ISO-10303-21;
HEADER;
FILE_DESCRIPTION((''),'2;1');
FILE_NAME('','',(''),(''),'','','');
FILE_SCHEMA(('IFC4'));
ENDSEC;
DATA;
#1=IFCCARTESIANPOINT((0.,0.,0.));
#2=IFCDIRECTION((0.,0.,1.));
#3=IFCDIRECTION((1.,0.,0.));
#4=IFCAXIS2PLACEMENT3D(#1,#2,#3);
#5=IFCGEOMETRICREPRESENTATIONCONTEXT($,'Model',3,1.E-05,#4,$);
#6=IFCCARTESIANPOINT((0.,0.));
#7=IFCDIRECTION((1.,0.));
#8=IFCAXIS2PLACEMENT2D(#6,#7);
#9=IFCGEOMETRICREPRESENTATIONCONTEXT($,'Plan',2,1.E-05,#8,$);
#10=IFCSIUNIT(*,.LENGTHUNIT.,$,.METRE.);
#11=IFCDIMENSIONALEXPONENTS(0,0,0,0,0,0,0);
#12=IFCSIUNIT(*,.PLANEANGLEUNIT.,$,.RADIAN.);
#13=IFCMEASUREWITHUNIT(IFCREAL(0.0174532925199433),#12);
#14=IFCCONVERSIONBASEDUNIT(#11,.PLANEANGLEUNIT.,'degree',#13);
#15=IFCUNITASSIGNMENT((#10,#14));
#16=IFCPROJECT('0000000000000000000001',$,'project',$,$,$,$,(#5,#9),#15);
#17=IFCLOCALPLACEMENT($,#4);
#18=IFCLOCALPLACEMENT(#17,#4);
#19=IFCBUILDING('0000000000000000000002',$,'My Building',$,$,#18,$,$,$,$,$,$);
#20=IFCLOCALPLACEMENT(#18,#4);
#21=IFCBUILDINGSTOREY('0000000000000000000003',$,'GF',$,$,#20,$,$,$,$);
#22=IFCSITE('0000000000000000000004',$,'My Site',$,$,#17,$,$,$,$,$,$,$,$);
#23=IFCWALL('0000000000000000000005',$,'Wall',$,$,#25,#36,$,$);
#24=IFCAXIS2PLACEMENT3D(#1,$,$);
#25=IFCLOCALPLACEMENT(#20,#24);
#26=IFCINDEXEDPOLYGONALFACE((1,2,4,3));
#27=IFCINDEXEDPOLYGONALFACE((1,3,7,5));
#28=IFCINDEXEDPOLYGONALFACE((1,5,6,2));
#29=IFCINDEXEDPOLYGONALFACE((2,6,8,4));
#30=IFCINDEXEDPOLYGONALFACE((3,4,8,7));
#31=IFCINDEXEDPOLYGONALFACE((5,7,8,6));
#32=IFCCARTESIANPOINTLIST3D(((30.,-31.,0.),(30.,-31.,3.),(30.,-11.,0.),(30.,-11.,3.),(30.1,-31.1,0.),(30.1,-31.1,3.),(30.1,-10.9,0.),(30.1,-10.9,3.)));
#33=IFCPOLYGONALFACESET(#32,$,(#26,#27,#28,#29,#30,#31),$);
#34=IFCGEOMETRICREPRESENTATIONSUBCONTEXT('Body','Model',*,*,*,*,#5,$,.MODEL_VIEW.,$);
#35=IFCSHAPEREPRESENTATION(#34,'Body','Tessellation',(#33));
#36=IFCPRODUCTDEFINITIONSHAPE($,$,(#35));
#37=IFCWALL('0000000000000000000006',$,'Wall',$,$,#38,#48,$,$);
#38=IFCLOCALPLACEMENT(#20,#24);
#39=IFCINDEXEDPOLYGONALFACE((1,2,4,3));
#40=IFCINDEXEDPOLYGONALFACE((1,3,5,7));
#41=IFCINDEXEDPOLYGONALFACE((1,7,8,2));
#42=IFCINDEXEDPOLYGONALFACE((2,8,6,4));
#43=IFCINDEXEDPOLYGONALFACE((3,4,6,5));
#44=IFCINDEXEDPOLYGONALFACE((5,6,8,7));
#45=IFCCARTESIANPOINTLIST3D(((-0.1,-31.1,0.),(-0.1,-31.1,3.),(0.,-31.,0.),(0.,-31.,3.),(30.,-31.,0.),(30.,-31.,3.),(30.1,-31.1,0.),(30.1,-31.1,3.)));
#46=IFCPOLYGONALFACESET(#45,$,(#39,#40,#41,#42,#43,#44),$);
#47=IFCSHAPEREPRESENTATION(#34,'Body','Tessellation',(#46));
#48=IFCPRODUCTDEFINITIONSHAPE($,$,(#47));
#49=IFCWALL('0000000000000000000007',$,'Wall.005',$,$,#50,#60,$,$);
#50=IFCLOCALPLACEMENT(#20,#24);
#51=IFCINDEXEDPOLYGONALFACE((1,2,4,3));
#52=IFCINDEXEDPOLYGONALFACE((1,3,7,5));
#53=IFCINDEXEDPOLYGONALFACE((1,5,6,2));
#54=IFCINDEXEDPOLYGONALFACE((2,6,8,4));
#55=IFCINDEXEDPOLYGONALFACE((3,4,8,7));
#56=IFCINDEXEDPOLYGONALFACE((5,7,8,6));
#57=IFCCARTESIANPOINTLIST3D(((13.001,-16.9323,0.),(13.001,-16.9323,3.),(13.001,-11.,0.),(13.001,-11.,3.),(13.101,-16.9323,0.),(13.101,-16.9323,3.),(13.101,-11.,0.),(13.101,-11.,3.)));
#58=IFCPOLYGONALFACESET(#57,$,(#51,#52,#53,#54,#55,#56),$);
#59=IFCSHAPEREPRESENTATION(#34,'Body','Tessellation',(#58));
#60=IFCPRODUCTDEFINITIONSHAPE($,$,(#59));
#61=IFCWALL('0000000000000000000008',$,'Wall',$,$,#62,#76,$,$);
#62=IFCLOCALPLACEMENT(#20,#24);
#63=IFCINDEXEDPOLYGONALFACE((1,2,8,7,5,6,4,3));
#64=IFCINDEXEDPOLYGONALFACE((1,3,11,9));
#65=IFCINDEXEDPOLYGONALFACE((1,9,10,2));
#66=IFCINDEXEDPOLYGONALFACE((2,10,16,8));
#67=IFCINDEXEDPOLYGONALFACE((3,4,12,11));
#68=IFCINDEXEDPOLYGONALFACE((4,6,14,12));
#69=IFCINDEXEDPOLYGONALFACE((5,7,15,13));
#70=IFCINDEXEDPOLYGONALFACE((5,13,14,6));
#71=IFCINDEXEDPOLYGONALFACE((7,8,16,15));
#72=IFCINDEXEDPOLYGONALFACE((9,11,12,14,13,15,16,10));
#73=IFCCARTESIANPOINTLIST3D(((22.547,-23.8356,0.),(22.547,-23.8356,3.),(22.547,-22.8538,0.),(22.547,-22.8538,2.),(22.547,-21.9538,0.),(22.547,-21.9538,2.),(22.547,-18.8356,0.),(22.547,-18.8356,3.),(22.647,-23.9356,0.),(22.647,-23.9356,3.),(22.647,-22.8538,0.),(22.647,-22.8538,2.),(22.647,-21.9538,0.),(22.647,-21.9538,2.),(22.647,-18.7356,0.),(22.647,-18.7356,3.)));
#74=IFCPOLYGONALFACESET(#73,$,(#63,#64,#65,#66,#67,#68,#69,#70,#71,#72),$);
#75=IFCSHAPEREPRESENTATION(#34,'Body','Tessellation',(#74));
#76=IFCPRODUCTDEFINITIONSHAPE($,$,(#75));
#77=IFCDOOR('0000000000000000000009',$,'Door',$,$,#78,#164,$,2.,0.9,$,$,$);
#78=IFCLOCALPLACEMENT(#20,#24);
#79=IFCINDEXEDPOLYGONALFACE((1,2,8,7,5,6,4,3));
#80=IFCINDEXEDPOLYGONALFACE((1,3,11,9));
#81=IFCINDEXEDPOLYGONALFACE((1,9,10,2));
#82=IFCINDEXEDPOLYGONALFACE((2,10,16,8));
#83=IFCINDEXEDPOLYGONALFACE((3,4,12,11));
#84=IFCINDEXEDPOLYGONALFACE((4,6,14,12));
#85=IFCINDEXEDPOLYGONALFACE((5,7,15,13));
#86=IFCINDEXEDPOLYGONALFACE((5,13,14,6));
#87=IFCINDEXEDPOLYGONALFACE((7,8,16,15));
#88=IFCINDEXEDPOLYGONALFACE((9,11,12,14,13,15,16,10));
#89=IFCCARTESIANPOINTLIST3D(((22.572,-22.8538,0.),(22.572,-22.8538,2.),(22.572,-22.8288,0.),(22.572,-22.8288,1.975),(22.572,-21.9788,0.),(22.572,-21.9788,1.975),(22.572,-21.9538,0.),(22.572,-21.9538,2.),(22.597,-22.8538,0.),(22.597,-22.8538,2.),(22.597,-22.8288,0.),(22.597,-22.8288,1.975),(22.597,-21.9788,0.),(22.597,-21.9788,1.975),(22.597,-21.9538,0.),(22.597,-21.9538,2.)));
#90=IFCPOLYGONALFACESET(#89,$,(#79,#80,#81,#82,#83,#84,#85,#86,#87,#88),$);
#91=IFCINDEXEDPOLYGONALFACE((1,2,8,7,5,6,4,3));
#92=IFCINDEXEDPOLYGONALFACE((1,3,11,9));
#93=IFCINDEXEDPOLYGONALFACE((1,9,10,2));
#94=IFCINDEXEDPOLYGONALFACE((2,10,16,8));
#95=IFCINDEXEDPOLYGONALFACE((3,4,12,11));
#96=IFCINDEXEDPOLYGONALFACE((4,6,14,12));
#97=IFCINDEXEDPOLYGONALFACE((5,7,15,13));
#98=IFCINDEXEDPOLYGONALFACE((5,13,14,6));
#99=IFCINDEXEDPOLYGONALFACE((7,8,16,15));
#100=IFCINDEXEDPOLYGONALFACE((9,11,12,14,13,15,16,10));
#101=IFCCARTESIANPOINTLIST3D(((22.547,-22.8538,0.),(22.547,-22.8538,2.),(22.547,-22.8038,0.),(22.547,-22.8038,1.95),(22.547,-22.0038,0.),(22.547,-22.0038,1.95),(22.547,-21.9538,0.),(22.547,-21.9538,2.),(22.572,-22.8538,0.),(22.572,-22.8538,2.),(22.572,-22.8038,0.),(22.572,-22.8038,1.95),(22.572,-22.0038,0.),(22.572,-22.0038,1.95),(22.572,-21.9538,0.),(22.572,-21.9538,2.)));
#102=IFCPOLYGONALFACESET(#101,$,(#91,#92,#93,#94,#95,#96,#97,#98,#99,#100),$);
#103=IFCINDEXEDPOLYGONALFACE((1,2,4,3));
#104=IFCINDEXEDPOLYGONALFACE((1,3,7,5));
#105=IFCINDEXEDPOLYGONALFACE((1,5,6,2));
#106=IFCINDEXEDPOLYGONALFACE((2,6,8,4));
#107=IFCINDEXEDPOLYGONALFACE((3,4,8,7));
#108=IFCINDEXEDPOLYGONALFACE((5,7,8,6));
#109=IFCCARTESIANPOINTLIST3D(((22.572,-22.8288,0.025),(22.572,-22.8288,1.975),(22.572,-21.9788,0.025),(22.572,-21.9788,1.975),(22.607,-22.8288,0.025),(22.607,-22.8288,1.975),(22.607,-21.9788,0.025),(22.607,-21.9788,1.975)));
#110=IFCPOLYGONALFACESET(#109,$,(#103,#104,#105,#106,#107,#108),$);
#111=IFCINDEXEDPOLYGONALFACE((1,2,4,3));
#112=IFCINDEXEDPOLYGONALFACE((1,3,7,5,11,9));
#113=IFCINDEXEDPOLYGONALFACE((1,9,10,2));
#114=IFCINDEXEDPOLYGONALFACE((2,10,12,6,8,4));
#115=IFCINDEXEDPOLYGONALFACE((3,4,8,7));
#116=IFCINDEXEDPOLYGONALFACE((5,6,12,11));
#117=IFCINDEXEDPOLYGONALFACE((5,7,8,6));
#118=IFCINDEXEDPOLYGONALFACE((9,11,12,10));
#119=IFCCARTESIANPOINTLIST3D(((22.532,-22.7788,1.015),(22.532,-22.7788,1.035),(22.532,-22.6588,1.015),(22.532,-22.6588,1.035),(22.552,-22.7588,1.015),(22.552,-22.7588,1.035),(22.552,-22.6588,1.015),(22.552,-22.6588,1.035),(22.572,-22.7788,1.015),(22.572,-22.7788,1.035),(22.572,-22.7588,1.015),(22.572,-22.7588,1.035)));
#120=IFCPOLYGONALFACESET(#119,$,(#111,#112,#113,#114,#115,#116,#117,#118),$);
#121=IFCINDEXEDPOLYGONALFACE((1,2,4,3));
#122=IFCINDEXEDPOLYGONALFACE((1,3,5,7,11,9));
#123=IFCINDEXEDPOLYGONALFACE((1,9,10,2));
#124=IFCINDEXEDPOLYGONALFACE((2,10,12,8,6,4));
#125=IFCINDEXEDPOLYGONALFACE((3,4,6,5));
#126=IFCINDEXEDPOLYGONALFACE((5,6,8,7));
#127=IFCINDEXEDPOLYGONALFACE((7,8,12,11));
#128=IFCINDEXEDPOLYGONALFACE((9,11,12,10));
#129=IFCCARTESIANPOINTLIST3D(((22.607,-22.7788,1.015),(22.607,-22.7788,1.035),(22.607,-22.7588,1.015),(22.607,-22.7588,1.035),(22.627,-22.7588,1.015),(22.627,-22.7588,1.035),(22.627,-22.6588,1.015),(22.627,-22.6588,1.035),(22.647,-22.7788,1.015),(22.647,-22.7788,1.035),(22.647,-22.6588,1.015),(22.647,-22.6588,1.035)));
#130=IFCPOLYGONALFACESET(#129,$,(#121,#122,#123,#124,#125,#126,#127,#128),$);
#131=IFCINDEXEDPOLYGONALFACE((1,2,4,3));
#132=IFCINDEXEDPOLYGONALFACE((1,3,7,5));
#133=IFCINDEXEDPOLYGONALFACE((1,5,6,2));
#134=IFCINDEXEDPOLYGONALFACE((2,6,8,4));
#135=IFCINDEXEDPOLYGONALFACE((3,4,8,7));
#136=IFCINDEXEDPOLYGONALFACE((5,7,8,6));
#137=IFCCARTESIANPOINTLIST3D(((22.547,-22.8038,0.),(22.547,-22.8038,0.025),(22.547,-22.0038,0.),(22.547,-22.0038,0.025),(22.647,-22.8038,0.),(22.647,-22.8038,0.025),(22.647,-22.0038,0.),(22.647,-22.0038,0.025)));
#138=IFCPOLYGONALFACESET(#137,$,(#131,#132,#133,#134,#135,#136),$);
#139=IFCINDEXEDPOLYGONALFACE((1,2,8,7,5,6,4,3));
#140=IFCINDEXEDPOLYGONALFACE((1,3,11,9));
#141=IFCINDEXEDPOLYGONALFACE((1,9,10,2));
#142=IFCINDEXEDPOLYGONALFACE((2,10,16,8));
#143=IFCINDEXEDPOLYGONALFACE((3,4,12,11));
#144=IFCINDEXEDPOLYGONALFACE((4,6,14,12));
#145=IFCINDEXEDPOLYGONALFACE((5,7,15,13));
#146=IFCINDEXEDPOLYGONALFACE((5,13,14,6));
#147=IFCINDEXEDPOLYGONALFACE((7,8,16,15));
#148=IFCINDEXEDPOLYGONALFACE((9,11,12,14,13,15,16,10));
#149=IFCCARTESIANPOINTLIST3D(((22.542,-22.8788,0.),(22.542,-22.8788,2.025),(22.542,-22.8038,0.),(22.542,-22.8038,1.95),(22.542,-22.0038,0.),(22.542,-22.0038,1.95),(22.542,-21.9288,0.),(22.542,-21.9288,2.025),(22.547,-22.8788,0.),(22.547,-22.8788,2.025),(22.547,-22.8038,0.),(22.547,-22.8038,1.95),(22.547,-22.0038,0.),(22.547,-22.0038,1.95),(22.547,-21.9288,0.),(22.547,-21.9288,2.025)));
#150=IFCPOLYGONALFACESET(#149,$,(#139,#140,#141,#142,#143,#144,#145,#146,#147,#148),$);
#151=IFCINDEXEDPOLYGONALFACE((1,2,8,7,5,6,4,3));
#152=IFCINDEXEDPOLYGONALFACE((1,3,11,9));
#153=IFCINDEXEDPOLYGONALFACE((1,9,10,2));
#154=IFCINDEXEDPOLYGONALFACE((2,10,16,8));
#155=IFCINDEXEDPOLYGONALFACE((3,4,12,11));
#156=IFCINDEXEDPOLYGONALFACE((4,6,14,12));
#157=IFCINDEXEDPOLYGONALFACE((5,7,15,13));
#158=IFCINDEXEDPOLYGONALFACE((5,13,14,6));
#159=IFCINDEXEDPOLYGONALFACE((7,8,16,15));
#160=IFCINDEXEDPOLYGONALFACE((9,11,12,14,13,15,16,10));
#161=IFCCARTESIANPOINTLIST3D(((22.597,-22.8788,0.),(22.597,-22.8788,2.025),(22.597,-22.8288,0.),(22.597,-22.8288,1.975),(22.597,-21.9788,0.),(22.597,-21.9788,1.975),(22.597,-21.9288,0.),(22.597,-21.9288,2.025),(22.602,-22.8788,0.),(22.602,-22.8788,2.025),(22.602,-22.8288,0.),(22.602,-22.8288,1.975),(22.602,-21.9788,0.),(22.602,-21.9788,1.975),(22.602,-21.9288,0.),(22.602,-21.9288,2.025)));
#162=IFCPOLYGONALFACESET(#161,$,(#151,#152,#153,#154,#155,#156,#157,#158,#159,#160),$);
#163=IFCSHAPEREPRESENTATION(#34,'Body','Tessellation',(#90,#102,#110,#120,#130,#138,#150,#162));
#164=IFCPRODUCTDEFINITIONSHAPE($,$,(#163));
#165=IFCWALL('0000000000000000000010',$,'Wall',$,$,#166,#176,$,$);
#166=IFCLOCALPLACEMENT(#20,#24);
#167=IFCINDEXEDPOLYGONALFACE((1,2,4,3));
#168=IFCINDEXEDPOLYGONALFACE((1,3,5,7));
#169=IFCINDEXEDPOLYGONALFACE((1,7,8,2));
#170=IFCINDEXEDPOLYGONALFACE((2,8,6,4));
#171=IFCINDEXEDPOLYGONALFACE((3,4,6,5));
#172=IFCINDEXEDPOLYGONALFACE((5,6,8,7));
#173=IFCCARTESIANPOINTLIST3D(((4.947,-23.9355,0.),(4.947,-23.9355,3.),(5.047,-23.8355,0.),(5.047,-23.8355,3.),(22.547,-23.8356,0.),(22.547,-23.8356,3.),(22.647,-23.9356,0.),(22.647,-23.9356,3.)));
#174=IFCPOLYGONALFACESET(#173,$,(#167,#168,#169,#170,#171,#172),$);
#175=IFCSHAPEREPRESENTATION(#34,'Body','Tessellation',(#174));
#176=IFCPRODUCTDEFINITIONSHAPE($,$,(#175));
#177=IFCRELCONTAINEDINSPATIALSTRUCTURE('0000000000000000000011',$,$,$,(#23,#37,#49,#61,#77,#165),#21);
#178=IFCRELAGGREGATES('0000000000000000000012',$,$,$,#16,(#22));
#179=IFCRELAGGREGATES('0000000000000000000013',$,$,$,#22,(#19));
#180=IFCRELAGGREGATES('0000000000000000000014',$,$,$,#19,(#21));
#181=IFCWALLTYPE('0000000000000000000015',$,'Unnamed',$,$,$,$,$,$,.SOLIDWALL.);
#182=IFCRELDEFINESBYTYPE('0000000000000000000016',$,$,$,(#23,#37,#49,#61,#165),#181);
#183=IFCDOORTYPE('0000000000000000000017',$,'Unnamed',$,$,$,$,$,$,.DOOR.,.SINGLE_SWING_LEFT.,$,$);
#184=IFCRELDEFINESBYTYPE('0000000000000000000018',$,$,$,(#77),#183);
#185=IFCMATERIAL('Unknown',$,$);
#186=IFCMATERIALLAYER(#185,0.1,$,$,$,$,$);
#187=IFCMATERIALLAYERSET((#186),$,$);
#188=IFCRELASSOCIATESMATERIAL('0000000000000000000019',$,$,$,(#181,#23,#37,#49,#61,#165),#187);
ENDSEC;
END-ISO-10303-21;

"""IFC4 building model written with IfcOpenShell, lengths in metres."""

from ifc_helpers import new_model, entity, si_unit, converted_unit, frame, origin_with_axes, origin_2d_with_axis, place, context, subcontext, project, spatial, line, indexed_curve, outline, extrude, shape, source, transform, mapped, material, layer, layer_set, layer_usage, type_object, type_shapes, element, fill, save


model = new_model("IFC4")

# Units and contexts
model_context = context("Model", 3, precision=1e-05, world=origin_with_axes())
plan_context = context("Plan", 2, precision=1e-05, world=origin_2d_with_axis())
body_context_1 = subcontext(model_context, "Body", "Model", "MODEL_VIEW")
body_context_2 = subcontext(plan_context, "Body", "Plan", "PLAN_VIEW")
ifc_project = project(units=[si_unit("LENGTHUNIT", "METRE"), converted_unit("PLANEANGLEUNIT", "degree", entity("IfcReal", 0.0174532925199433), si_unit("PLANEANGLEUNIT", "RADIAN"), dimensions=[0, 0, 0, 0, 0, 0, 0])], contexts=[model_context, plan_context])

# Site, building, storey
site_placement = place(None, origin_with_axes())
site = spatial("IfcSite", under=ifc_project, at=site_placement, Name="My Site")
building_placement = place(site_placement, origin_with_axes())
building = spatial("IfcBuilding", under=site, at=building_placement, Name="My Building")
storey_placement = place(building_placement, origin_with_axes())
storey = spatial("IfcBuildingStorey", under=building, at=storey_placement, Name="GF")

# Walls
ifc_material = material(Name="Unknown")
ifc_layer = layer(ifc_material, 0.1)
ifc_layer_set = layer_set([ifc_layer])
ifc_layer_usage_1 = layer_usage(ifc_layer_set, "AXIS2", "POSITIVE", 0.0)
wall_type = type_object("IfcWallType", Name="Unnamed", PredefinedType="SOLIDWALL", material=ifc_layer_set)
wall_1_placement = place(storey_placement, frame((30.0, -11.0, 0.0), z_axis=(0.0, 0.0, 1.0), x_axis=(0.0, -1.0, 0.0)))
element("IfcWall", 1, at=wall_1_placement, inside=storey, type_object=wall_type, material=ifc_layer_usage_1, Name="Wall", context=body_context_1, shape_type="SweptSolid", body=[
    extrude(outline(indexed_curve([(0.0, 0.0), (-0.1, 0.1), (20.1, 0.1), (20.0, 0.0)], segments=[line(1, 2, 3, 4, 1)])), origin_with_axes(), (0.0, 0.0, 1.0), 3.0),
])
ifc_layer_usage_2 = layer_usage(ifc_layer_set, "AXIS2", "POSITIVE", 0.0)
wall_2_placement = place(storey_placement, frame((30.0, -31.0, 0.0), z_axis=(0.0, 0.0, 1.0), x_axis=(-1.0, 0.0, 0.0)))
element("IfcWall", 2, at=wall_2_placement, inside=storey, type_object=wall_type, material=ifc_layer_usage_2, Name="Wall", context=body_context_1, shape_type="SweptSolid", body=[
    extrude(outline(indexed_curve([(0.0, 0.0), (-0.1, 0.1), (30.1, 0.1), (30.0, 0.0)], segments=[line(1, 2, 3, 4, 1)])), origin_with_axes(), (0.0, 0.0, 1.0), 3.0),
])
ifc_layer_usage_3 = layer_usage(ifc_layer_set, "AXIS2", "POSITIVE", 0.0)
wall_3_placement = place(storey_placement, frame((13.101, -16.9323, 0.0), z_axis=(0.0, 0.0, 1.0), x_axis=(0.0, 1.0, 0.0)))
element("IfcWall", 3, at=wall_3_placement, inside=storey, type_object=wall_type, material=ifc_layer_usage_3, Name="Wall.005", context=body_context_1, shape_type="SweptSolid", body=[
    extrude(outline(indexed_curve([(0.0, 0.0), (0.0, 0.1), (5.9323, 0.1), (5.9323, 0.0)], segments=[line(1, 2, 3, 4, 1)])), origin_with_axes(), (0.0, 0.0, 1.0), 3.0),
])

# Wall, opening, door
ifc_layer_usage_4 = layer_usage(ifc_layer_set, "AXIS2", "POSITIVE", 0.0)
wall_4_placement = place(storey_placement, frame((22.547, -18.8356, 0.0), z_axis=(0.0, 0.0, 1.0), x_axis=(0.0, -1.0, 0.0)))
wall_4 = element("IfcWall", 4, at=wall_4_placement, inside=storey, type_object=wall_type, material=ifc_layer_usage_4, Name="Wall", context=body_context_1, shape_type="SweptSolid", body=[
    extrude(outline(indexed_curve([(0.0, 0.0), (-0.1, 0.1), (5.1, 0.1), (5.0, 0.0)], segments=[line(1, 2, 3, 4, 1)])), origin_with_axes(), (0.0, 0.0, 1.0), 3.0),
])
shared_shape_1 = source(origin_with_axes(), body_context_1, "Body", "SweptSolid", [
    extrude(outline(indexed_curve([(0.0, 0.0), (0.9, 0.0), (0.9, 2.0), (0.0, 2.0)], segments=[line(1, 2, 3, 4, 1)])), frame((0.0, -0.6, 0.0), z_axis=(0.0, -1.0, 0.0), x_axis=(1.0, 0.0, 0.0)), (0.0, 0.0, -1.0), 1.2),
])
opening_1_placement = place(wall_4_placement, frame((3.1182, 0.0, 0.0), z_axis=(0.0, 0.0, 1.0), x_axis=(1.0, 0.0, 0.0)))
opening_1 = element("IfcOpeningElement", 5, at=opening_1_placement, cuts=wall_4, PredefinedType="OPENING", context=body_context_1, shape_type="MappedRepresentation", body=[
    mapped(shared_shape_1, transform((0.0, 0.0, 0.0), x_axis=(1.0, 0.0, 0.0), y_axis=(0.0, 1.0, 0.0), z_axis=(0.0, 0.0, 1.0), scale=1.0)),
])
door_type = type_object("IfcDoorType", Name="Unnamed", OperationType="SINGLE_SWING_LEFT", PredefinedType="DOOR")
shared_shape_2 = source(origin_with_axes(), body_context_1, "Body", "SweptSolid", [
    extrude(outline(indexed_curve([(0.0, 0.0), (0.0, 2.0), (0.9, 2.0), (0.9, 0.0), (0.875, 0.0), (0.875, 1.975), (0.025, 1.975), (0.025, 0.0)], segments=[line(1, 2, 3, 4, 5, 6, 7, 8, 1)])), frame((0.0, 0.025, 0.0), z_axis=(0.0, -1.0, 0.0), x_axis=(1.0, 0.0, 0.0)), (0.0, 0.0, -1.0), 0.025),
    extrude(outline(indexed_curve([(0.0, 0.0), (0.0, 2.0), (0.9, 2.0), (0.9, 0.0), (0.85, 0.0), (0.85, 1.95), (0.05, 1.95), (0.05, 0.0)], segments=[line(1, 2, 3, 4, 5, 6, 7, 8, 1)])), frame((0.0, 0.0, 0.0), z_axis=(0.0, -1.0, 0.0), x_axis=(1.0, 0.0, 0.0)), (0.0, 0.0, -1.0), 0.025),
    extrude(outline(indexed_curve([(0.0, 0.0), (0.85, 0.0), (0.85, 0.035), (0.0, 0.035)], segments=[line(1, 2, 3, 4, 1)])), frame((0.025, 0.025, 0.025), z_axis=(0.0, 0.0, 1.0), x_axis=(1.0, 0.0, 0.0)), (0.0, 0.0, 1.0), 1.95),
    extrude(outline(indexed_curve([(0.0, 0.0), (0.0, -0.04), (-0.12, -0.04), (-0.12, -0.02), (-0.02, -0.02), (-0.02, 0.0)], segments=[line(1, 2, 3, 4, 5, 6, 1)])), frame((0.825, 0.025, 1.015), z_axis=(0.0, 0.0, 1.0), x_axis=(1.0, 0.0, 0.0)), (0.0, 0.0, 1.0), 0.02),
    extrude(outline(indexed_curve([(0.0, 0.0), (0.0, 0.04), (-0.12, 0.04), (-0.12, 0.02), (-0.02, 0.02), (-0.02, 0.0)], segments=[line(1, 2, 3, 4, 5, 6, 1)])), frame((0.825, 0.06, 1.015), z_axis=(0.0, 0.0, 1.0), x_axis=(1.0, 0.0, 0.0)), (0.0, 0.0, 1.0), 0.02),
    extrude(outline(indexed_curve([(0.0, 0.0), (0.8, 0.0), (0.8, 0.1), (0.0, 0.1)], segments=[line(1, 2, 3, 4, 1)])), frame((0.05, 0.0, 0.0), z_axis=(0.0, 0.0, 1.0), x_axis=(1.0, 0.0, 0.0)), (0.0, 0.0, 1.0), 0.025),
    extrude(outline(indexed_curve([(0.0, 0.0), (0.0, 2.025), (0.95, 2.025), (0.95, 0.0), (0.875, 0.0), (0.875, 1.95), (0.075, 1.95), (0.075, 0.0)], segments=[line(1, 2, 3, 4, 5, 6, 7, 8, 1)])), frame((-0.025, -0.005, 0.0), z_axis=(0.0, -1.0, 0.0), x_axis=(1.0, 0.0, 0.0)), (0.0, 0.0, -1.0), 0.005),
    extrude(outline(indexed_curve([(0.0, 0.0), (0.0, 2.025), (0.95, 2.025), (0.95, 0.0), (0.9, 0.0), (0.9, 1.975), (0.05, 1.975), (0.05, 0.0)], segments=[line(1, 2, 3, 4, 5, 6, 7, 8, 1)])), frame((-0.025, 0.05, 0.0), z_axis=(0.0, -1.0, 0.0), x_axis=(1.0, 0.0, 0.0)), (0.0, 0.0, -1.0), 0.005),
])
shared_shape_3 = source(origin_with_axes(), body_context_2, "Body", "Curve2D", [
    entity("IfcIndexedPolyCurve", entity("IfcCartesianPointList2D", [[0.0, 0.0], [0.0, 0.05], [0.025, 0.05], [0.025, 0.025], [0.05, 0.025], [0.05, 0.0]]), [entity("IfcLineIndex", [1, 2, 3, 4, 5, 6, 1])]),
    entity("IfcIndexedPolyCurve", entity("IfcCartesianPointList2D", [[0.9, 0.0], [0.9, 0.05], [0.875, 0.05], [0.875, 0.025], [0.85, 0.025], [0.85, 0.0]]), [entity("IfcLineIndex", [1, 2, 3, 4, 5, 6, 1])]),
    entity("IfcTrimmedCurve", entity("IfcEllipse", entity("IfcAxis2Placement2D", entity("IfcCartesianPoint", [0.06, 0.05]), entity("IfcDirection", [1.0, 0.0])), 0.815, 0.85), [entity("IfcCartesianPoint", [0.875, 0.05])], [entity("IfcCartesianPoint", [0.06, 0.9])], True, "CARTESIAN"),
    entity("IfcIndexedPolyCurve", entity("IfcCartesianPointList2D", [[0.025, 0.05], [0.06, 0.05], [0.06, 0.9], [0.025, 0.9]]), [entity("IfcLineIndex", [1, 2, 3, 4, 1])]),
])
type_shapes(door_type, [shared_shape_2, shared_shape_3])
door_1_placement = place(opening_1_placement, frame((0.0, 0.0, 0.0), z_axis=(0.0, 0.0, 1.0), x_axis=(1.0, 0.0, 0.0)))
door_1 = element("IfcDoor", 6, at=door_1_placement, inside=storey, type_object=door_type, Name="Door", OverallHeight=2.0, OverallWidth=0.9, shapes=[
    shape(body_context_1, "Body", "MappedRepresentation", [mapped(shared_shape_2, transform((0.0, 0.0, 0.0), x_axis=(1.0, 0.0, 0.0), y_axis=(0.0, 1.0, 0.0), z_axis=(0.0, 0.0, 1.0), scale=1.0))]),
    shape(body_context_2, "Body", "MappedRepresentation", [mapped(shared_shape_3, transform((0.0, 0.0, 0.0), x_axis=(1.0, 0.0, 0.0), y_axis=(0.0, 1.0, 0.0), z_axis=(0.0, 0.0, 1.0), scale=1.0))]),
])
fill(opening_1, door_1)

# Wall
ifc_layer_usage_5 = layer_usage(ifc_layer_set, "AXIS2", "POSITIVE", 0.0)
wall_5_placement = place(storey_placement, frame((22.547, -23.8356, 0.0), z_axis=(0.0, 0.0, 1.0), x_axis=(-1.0, 0.0, 0.0)))
element("IfcWall", 7, at=wall_5_placement, inside=storey, type_object=wall_type, material=ifc_layer_usage_5, Name="Wall", context=body_context_1, shape_type="SweptSolid", body=[
    extrude(outline(indexed_curve([(0.0, 0.0), (-0.1, 0.1), (17.6, 0.1), (17.5, 0.0)], segments=[line(1, 2, 3, 4, 1)])), origin_with_axes(), (0.0, 0.0, 1.0), 3.0),
])

save(model, "model.ifc")
